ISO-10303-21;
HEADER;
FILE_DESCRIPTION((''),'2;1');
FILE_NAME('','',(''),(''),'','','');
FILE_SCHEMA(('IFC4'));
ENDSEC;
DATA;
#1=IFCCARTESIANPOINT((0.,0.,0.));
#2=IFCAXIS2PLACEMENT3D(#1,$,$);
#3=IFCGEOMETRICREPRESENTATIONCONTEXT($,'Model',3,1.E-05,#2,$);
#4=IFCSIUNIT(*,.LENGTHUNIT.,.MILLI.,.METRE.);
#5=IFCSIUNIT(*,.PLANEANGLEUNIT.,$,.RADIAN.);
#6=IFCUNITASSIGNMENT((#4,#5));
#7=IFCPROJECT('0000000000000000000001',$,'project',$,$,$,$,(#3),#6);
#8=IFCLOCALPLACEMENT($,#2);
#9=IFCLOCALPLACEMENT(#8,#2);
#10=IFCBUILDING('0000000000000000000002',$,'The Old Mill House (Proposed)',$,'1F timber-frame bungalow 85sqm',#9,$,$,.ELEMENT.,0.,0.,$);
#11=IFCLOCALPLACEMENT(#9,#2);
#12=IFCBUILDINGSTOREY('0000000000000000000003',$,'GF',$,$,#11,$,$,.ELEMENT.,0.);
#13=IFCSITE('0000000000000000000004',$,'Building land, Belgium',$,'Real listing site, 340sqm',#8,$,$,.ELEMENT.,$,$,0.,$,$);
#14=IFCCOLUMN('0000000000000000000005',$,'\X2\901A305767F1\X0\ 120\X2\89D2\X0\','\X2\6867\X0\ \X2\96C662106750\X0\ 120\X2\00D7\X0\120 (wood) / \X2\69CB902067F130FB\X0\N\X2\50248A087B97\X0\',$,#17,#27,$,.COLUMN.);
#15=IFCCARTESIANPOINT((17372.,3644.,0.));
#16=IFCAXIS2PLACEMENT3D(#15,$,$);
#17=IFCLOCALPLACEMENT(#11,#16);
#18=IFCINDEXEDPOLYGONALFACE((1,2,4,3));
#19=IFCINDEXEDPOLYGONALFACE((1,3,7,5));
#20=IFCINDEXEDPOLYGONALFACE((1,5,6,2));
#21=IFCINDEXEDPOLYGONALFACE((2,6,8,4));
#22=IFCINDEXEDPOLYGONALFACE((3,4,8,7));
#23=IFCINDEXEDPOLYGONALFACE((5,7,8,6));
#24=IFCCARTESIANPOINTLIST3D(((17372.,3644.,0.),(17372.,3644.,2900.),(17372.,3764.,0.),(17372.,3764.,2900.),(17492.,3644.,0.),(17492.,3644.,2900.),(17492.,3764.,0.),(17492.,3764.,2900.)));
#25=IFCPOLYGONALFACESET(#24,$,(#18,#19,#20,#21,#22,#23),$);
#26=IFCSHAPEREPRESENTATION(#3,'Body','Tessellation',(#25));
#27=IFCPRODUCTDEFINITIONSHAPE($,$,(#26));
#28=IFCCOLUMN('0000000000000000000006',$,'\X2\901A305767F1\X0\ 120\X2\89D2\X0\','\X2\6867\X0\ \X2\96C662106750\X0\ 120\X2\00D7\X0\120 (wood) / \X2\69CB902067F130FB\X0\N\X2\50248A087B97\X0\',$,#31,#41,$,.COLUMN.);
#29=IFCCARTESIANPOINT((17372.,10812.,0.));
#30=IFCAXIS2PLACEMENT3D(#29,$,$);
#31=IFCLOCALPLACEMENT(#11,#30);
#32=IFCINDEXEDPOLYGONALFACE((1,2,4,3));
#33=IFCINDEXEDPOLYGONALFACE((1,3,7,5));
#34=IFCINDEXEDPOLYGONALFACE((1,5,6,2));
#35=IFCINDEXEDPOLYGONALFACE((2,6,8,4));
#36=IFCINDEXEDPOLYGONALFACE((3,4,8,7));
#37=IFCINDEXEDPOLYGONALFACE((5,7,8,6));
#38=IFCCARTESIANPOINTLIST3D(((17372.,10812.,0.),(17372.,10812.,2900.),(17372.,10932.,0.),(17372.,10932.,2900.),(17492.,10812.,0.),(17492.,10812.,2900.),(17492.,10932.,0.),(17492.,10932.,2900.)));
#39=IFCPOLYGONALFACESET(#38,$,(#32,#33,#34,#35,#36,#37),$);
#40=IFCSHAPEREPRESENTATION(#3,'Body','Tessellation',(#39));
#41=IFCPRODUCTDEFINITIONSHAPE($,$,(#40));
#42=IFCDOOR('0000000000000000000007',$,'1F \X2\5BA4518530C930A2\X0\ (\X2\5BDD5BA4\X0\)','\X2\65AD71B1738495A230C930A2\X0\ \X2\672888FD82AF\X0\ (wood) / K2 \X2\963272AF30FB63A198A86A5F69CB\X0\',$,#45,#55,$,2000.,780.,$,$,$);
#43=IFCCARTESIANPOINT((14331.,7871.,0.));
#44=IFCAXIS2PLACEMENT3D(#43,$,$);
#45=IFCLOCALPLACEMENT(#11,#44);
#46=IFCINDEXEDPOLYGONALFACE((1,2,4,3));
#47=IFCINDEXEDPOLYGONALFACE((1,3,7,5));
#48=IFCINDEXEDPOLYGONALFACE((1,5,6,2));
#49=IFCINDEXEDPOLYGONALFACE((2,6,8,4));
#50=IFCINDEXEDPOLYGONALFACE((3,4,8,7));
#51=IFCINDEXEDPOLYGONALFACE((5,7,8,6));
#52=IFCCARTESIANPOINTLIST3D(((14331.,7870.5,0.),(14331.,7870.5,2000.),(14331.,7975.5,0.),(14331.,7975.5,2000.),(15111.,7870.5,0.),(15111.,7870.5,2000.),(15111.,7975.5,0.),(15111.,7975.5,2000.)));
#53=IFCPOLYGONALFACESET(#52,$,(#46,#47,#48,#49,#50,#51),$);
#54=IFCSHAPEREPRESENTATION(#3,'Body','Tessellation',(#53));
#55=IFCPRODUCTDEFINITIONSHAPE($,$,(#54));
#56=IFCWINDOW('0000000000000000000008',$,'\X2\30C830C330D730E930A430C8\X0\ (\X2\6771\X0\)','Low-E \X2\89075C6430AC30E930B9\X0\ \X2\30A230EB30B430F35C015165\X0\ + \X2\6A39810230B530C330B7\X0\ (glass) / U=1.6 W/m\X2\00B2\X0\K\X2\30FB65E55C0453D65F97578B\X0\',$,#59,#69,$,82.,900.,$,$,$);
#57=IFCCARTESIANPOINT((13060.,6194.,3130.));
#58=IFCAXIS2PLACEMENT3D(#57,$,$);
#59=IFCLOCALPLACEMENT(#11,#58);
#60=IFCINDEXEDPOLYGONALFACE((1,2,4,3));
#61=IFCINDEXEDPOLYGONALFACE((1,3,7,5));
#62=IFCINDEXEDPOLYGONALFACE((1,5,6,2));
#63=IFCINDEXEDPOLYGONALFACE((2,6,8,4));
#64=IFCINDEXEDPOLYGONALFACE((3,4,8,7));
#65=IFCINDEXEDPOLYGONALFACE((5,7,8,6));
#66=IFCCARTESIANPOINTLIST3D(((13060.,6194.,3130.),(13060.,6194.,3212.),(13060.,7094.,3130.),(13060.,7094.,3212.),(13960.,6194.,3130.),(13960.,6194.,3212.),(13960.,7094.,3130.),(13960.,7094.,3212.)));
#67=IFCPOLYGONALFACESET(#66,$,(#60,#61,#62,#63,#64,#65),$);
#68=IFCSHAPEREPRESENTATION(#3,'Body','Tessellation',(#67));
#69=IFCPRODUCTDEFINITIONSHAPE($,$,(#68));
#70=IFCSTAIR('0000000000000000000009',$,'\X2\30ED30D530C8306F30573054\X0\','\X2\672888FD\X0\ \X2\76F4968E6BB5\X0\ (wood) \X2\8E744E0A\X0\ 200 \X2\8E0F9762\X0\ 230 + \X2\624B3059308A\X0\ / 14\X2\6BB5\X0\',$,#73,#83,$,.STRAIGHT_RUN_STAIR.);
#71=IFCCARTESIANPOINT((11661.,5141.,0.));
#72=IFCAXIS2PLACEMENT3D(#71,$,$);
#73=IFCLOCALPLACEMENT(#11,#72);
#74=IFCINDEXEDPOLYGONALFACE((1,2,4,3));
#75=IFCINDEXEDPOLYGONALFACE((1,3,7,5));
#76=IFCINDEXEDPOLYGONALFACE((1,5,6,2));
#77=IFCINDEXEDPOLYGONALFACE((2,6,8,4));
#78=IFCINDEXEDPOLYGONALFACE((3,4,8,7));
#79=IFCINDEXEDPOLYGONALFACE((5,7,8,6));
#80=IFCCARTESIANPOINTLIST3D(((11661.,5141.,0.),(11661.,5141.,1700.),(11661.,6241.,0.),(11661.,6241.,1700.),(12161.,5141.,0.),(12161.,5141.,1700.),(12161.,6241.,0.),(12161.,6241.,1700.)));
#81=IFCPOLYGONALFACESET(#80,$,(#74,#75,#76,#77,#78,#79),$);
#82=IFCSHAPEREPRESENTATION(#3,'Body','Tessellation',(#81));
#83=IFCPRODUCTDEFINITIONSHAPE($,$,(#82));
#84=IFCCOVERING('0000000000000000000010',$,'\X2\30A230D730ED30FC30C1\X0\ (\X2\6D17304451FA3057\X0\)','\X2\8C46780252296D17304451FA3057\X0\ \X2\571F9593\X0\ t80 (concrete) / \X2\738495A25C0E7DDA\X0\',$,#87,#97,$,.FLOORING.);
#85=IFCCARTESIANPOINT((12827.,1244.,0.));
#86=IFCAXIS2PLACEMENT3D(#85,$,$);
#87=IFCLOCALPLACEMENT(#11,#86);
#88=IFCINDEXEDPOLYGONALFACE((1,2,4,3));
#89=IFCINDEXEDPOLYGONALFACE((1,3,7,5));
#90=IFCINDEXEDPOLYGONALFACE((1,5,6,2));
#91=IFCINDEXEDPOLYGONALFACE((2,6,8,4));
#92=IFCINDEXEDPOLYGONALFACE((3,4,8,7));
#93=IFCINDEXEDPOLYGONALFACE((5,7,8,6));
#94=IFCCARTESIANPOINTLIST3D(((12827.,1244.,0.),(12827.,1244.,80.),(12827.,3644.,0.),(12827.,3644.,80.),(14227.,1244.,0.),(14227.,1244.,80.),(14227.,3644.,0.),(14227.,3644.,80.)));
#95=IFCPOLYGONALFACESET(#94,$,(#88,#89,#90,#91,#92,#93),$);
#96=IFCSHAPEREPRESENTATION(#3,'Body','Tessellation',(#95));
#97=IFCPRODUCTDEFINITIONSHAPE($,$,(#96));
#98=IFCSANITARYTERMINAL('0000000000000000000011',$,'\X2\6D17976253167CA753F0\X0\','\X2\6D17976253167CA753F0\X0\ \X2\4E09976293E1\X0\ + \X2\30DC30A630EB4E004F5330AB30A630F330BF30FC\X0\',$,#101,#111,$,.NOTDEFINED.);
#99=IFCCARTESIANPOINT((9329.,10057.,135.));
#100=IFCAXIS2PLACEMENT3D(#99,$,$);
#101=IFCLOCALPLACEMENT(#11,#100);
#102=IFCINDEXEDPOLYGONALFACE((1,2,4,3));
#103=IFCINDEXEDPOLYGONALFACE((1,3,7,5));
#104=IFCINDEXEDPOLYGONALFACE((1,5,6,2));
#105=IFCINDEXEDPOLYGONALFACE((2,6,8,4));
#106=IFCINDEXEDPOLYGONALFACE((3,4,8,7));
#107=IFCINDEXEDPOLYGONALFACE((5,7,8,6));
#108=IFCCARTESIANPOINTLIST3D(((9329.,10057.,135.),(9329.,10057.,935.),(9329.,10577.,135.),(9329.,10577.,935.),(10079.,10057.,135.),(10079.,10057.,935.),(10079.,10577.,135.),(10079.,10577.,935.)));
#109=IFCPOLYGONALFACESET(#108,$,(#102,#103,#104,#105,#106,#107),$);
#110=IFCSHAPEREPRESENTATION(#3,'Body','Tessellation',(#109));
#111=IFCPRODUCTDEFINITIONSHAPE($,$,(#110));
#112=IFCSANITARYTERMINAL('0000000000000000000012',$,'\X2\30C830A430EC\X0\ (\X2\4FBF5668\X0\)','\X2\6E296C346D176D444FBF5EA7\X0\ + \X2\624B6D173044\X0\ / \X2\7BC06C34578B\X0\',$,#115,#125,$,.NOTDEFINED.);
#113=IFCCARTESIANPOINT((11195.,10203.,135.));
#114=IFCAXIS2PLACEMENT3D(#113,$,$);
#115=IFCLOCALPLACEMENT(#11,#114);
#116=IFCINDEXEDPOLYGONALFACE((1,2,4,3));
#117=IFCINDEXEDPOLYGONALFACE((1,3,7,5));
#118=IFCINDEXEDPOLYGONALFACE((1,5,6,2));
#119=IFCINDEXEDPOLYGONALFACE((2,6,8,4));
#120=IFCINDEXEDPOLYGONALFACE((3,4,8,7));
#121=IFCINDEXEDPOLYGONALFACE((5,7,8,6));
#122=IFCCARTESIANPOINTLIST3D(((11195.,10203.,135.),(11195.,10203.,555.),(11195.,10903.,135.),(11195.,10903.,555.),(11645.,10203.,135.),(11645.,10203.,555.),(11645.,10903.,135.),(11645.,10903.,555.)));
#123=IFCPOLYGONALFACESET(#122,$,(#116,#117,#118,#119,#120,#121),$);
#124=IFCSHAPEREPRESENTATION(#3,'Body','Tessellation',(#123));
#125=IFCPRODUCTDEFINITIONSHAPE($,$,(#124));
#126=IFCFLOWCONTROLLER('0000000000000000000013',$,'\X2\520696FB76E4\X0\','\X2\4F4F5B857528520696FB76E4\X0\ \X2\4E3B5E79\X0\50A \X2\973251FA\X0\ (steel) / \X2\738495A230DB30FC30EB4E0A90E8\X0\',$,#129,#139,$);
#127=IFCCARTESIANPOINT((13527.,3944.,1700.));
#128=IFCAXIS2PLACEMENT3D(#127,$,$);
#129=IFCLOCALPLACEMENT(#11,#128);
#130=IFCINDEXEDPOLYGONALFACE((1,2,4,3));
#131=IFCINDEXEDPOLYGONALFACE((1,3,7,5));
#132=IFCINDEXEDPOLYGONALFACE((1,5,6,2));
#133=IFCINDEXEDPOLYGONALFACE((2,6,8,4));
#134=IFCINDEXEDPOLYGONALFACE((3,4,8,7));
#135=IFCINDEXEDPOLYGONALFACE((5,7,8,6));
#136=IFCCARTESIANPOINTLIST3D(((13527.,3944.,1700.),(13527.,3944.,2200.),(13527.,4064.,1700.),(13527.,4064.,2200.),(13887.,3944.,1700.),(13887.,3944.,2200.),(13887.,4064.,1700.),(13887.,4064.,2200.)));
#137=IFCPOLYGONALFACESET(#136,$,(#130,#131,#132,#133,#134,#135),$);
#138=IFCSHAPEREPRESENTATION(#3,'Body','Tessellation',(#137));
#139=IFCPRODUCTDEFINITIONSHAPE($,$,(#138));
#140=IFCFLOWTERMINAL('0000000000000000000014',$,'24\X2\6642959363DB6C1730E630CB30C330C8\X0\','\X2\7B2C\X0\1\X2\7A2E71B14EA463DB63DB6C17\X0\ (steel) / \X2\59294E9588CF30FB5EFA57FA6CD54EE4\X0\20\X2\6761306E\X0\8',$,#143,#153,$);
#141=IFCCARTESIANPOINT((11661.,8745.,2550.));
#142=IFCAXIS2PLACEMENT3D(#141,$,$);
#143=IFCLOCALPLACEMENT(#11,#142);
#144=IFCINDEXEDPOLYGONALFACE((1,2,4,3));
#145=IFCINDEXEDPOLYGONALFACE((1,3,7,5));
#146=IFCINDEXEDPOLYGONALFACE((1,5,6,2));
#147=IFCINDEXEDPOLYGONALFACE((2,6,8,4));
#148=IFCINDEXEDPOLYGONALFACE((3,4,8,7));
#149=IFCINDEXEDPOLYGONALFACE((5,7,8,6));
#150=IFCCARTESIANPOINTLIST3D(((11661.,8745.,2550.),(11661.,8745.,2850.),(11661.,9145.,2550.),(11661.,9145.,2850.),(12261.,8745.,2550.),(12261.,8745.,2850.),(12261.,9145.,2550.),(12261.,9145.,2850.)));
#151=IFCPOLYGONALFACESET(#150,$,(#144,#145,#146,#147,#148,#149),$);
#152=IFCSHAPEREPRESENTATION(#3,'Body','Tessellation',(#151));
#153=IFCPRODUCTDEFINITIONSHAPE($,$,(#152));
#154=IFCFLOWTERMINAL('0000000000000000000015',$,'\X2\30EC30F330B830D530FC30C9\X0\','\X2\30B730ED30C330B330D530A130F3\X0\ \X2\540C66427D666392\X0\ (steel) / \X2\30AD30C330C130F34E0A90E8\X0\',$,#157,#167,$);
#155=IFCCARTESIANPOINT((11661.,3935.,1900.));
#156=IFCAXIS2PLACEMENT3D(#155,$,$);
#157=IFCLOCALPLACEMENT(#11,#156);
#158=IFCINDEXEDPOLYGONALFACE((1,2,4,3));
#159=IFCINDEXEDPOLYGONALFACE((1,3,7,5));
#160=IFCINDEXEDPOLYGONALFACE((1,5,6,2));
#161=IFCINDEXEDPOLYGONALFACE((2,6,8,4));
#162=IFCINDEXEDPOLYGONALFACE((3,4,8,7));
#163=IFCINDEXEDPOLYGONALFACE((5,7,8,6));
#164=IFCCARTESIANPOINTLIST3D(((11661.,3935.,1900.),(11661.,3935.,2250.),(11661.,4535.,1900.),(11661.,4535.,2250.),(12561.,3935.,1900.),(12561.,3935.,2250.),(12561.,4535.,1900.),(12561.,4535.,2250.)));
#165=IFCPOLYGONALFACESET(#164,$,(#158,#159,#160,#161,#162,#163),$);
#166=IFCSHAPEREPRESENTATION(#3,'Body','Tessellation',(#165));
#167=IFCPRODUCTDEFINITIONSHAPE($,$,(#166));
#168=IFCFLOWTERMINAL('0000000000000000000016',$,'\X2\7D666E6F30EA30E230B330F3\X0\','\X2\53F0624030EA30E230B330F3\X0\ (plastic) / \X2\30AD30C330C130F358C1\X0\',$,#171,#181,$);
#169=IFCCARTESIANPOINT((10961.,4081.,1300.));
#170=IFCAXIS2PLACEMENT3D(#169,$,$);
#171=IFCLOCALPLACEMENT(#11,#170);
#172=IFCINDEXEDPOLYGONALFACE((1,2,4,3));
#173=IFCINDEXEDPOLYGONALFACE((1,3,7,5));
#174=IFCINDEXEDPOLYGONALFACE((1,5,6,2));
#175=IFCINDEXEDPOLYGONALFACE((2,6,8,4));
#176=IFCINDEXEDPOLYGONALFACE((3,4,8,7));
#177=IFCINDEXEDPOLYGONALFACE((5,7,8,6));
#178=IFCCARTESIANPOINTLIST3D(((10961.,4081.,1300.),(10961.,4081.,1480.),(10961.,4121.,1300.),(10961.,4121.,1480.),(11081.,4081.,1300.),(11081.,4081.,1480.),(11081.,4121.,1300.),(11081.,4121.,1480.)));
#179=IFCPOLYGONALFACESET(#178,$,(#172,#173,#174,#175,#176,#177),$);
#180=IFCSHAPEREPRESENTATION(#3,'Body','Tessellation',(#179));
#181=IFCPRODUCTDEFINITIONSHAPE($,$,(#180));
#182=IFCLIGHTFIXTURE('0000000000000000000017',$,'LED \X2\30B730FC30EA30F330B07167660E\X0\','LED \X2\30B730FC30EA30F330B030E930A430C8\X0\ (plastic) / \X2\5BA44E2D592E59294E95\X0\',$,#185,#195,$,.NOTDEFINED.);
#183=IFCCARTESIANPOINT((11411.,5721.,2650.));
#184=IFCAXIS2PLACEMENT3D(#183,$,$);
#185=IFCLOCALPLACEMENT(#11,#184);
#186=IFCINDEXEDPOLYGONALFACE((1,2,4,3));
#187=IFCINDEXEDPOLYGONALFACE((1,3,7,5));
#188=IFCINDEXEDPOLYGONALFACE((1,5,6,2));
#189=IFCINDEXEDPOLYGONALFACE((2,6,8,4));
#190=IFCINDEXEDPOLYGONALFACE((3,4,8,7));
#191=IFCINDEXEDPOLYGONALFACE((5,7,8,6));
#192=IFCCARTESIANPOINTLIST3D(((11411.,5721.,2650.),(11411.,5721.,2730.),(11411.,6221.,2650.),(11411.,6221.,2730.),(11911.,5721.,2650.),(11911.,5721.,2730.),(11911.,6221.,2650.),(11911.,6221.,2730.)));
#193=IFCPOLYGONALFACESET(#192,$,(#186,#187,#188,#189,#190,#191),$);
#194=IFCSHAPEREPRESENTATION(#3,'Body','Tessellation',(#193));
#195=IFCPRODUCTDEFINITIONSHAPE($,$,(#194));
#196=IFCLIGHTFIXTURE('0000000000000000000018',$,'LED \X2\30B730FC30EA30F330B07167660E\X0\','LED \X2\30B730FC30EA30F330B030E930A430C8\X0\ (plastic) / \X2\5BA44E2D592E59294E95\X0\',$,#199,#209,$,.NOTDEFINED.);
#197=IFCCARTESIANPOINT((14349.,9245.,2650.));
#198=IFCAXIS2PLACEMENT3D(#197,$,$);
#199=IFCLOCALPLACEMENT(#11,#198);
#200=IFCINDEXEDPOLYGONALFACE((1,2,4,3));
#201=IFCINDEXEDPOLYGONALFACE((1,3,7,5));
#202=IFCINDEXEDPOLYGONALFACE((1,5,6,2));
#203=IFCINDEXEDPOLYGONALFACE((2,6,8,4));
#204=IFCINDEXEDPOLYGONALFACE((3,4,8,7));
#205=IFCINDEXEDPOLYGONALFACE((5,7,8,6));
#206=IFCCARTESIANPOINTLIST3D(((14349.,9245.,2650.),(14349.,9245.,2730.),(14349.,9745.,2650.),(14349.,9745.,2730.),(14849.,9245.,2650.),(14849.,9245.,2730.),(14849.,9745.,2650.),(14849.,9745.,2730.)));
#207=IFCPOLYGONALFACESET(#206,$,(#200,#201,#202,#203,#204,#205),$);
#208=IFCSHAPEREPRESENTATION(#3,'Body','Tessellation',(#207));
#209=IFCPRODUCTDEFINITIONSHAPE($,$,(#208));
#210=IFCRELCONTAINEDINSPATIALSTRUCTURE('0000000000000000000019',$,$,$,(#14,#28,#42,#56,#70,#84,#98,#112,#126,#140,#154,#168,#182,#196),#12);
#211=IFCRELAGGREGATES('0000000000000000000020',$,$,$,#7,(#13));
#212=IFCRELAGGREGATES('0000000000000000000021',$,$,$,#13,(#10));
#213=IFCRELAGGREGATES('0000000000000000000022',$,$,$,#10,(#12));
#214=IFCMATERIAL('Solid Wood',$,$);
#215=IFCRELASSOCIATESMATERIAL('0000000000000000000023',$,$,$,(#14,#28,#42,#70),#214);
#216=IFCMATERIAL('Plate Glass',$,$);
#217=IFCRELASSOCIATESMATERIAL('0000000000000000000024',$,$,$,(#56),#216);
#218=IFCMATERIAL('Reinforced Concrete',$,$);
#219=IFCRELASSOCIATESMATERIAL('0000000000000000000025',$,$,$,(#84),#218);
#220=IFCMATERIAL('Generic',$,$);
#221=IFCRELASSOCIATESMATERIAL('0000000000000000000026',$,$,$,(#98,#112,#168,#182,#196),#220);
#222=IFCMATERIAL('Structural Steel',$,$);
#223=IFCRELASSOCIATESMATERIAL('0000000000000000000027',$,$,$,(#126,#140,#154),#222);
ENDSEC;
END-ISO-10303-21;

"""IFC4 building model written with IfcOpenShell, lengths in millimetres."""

from ifc_helpers import new_model, si_unit, frame, frame_2d, origin, place, context, project, spatial, rectangle, extrude, material, element, save


model = new_model("IFC4")

# Units and contexts
model_context = context("Model", 3, precision=1e-05, world=origin())
ifc_project = project(units=[si_unit("LENGTHUNIT", "METRE", prefix="MILLI"), si_unit("PLANEANGLEUNIT", "RADIAN")], contexts=[model_context])

# Site, building, storey
site_placement = place(None, origin())
site = spatial("IfcSite", under=ifc_project, at=site_placement, Name="Building land, Belgium", ObjectType="Real listing site, 340sqm", CompositionType="ELEMENT", RefElevation=0.0)
building_placement = place(site_placement, origin())
building = spatial("IfcBuilding", under=site, at=building_placement, Name="The Old Mill House (Proposed)", ObjectType="1F timber-frame bungalow 85sqm", CompositionType="ELEMENT", ElevationOfRefHeight=0.0, ElevationOfTerrain=0.0)
storey_placement = place(building_placement, origin())
storey = spatial("IfcBuildingStorey", under=building, at=storey_placement, Name="GF", CompositionType="ELEMENT", Elevation=0.0)

# Columns
ifc_material_1 = material(Name="Solid Wood")
column_1_placement = place(storey_placement, frame((17372.0, 3644.0, 0.0)))
element("IfcColumn", 1, at=column_1_placement, inside=storey, material=ifc_material_1, Name="通し柱 120角", Description="桧 集成材 120×120 (wood) / 構造柱・N値計算", PredefinedType="COLUMN", context=model_context, shape_type="SweptSolid", body=[
    extrude(rectangle(XDim=120.0, YDim=120.0, at=frame_2d((60.0, 60.0))), frame((17372.0, 3644.0, 0.0)), (0.0, 0.0, 1.0), 2900.0),
])
column_2_placement = place(storey_placement, frame((17372.0, 10812.0, 0.0)))
element("IfcColumn", 2, at=column_2_placement, inside=storey, material=ifc_material_1, Name="通し柱 120角", Description="桧 集成材 120×120 (wood) / 構造柱・N値計算", PredefinedType="COLUMN", context=model_context, shape_type="SweptSolid", body=[
    extrude(rectangle(XDim=120.0, YDim=120.0, at=frame_2d((60.0, 60.0))), frame((17372.0, 10812.0, 0.0)), (0.0, 0.0, 1.0), 2900.0),
])

# Shared definitions
ifc_material_2 = material(Name="Plate Glass")

# Door
door_placement = place(storey_placement, frame((14331.0, 7871.0, 0.0)))
element("IfcDoor", 3, at=door_placement, inside=storey, material=ifc_material_1, Name="1F 室内ドア (寝室)", Description="断熱玄関ドア 木製芯 (wood) / K2 防犯・採風機構", OverallHeight=2000.0, OverallWidth=780.0, context=model_context, shape_type="SweptSolid", body=[
    extrude(rectangle(XDim=780.0, YDim=105.0, at=frame_2d((390.0, 52.0))), frame((14331.0, 7871.0, 0.0)), (0.0, 0.0, 1.0), 2000.0),
])

# Window
window_1_placement = place(storey_placement, frame((13060.0, 6194.0, 3130.0)))
element("IfcWindow", 4, at=window_1_placement, inside=storey, material=ifc_material_2, Name="トップライト (東)", Description="Low-E 複層ガラス アルゴン封入 + 樹脂サッシ (glass) / U=1.6 W/m²K・日射取得型", OverallHeight=82.0, OverallWidth=900.0, context=model_context, shape_type="SweptSolid", body=[
    extrude(rectangle(XDim=900.0, YDim=900.0, at=frame_2d((450.0, 450.0))), frame((13060.0, 6194.0, 3130.0)), (0.0, 0.0, 1.0), 82.0),
])

# Stair
stair_placement = place(storey_placement, frame((11661.0, 5141.0, 0.0)))
element("IfcStair", 5, at=stair_placement, inside=storey, material=ifc_material_1, Name="ロフトはしご", Description="木製 直階段 (wood) 蹴上 200 踏面 230 + 手すり / 14段", PredefinedType="STRAIGHT_RUN_STAIR", context=model_context, shape_type="SweptSolid", body=[
    extrude(rectangle(XDim=500.0, YDim=1100.0, at=frame_2d((250.0, 550.0))), frame((11661.0, 5141.0, 0.0)), (0.0, 0.0, 1.0), 1700.0),
])

# Covering
ifc_material_3 = material(Name="Reinforced Concrete")
covering_placement = place(storey_placement, frame((12827.0, 1244.0, 0.0)))
element("IfcCovering", 6, at=covering_placement, inside=storey, material=ifc_material_3, Name="アプローチ (洗い出し)", Description="豆砂利洗い出し 土間 t80 (concrete) / 玄関導線", PredefinedType="FLOORING", context=model_context, shape_type="SweptSolid", body=[
    extrude(rectangle(XDim=1400.0, YDim=2400.0, at=frame_2d((700.0, 1200.0))), frame((12827.0, 1244.0, 0.0)), (0.0, 0.0, 1.0), 80.0),
])

# Sanitary terminals
ifc_material_4 = material(Name="Generic")
sanitary_terminal_1_placement = place(storey_placement, frame((9329.0, 10057.0, 135.0)))
element("IfcSanitaryTerminal", 7, at=sanitary_terminal_1_placement, inside=storey, material=ifc_material_4, Name="洗面化粧台", Description="洗面化粧台 三面鏡 + ボウル一体カウンター", PredefinedType="NOTDEFINED", context=model_context, shape_type="SweptSolid", body=[
    extrude(rectangle(XDim=750.0, YDim=520.0, at=frame_2d((375.0, 260.0))), frame((9329.0, 10057.0, 135.0)), (0.0, 0.0, 1.0), 800.0),
])
sanitary_terminal_2_placement = place(storey_placement, frame((11195.0, 10203.0, 135.0)))
element("IfcSanitaryTerminal", 8, at=sanitary_terminal_2_placement, inside=storey, material=ifc_material_4, Name="トイレ (便器)", Description="温水洗浄便座 + 手洗い / 節水型", PredefinedType="NOTDEFINED", context=model_context, shape_type="SweptSolid", body=[
    extrude(rectangle(XDim=450.0, YDim=700.0, at=frame_2d((225.0, 350.0))), frame((11195.0, 10203.0, 135.0)), (0.0, 0.0, 1.0), 420.0),
])

# Flow controller
ifc_material_5 = material(Name="Structural Steel")
flow_controller_placement = place(storey_placement, frame((13527.0, 3944.0, 1700.0)))
element("IfcFlowController", 9, at=flow_controller_placement, inside=storey, material=ifc_material_5, Name="分電盤", Description="住宅用分電盤 主幹50A 露出 (steel) / 玄関ホール上部", context=model_context, shape_type="SweptSolid", body=[
    extrude(rectangle(XDim=360.0, YDim=120.0, at=frame_2d((180.0, 60.0))), frame((13527.0, 3944.0, 1700.0)), (0.0, 0.0, 1.0), 500.0),
])

# Flow terminals
flow_terminal_1_placement = place(storey_placement, frame((11661.0, 8745.0, 2550.0)))
element("IfcFlowTerminal", 10, at=flow_terminal_1_placement, inside=storey, material=ifc_material_5, Name="24時間換気ユニット", Description="第1種熱交換換気 (steel) / 天井裏・建基法令20条の8", context=model_context, shape_type="SweptSolid", body=[
    extrude(rectangle(XDim=600.0, YDim=400.0, at=frame_2d((300.0, 200.0))), frame((11661.0, 8745.0, 2550.0)), (0.0, 0.0, 1.0), 300.0),
])
flow_terminal_2_placement = place(storey_placement, frame((11661.0, 3935.0, 1900.0)))
element("IfcFlowTerminal", 11, at=flow_terminal_2_placement, inside=storey, material=ifc_material_5, Name="レンジフード", Description="シロッコファン 同時給排 (steel) / キッチン上部", context=model_context, shape_type="SweptSolid", body=[
    extrude(rectangle(XDim=900.0, YDim=600.0, at=frame_2d((450.0, 300.0))), frame((11661.0, 3935.0, 1900.0)), (0.0, 0.0, 1.0), 350.0),
])
flow_terminal_3_placement = place(storey_placement, frame((10961.0, 4081.0, 1300.0)))
element("IfcFlowTerminal", 12, at=flow_terminal_3_placement, inside=storey, material=ifc_material_4, Name="給湯リモコン", Description="台所リモコン (plastic) / キッチン壁", context=model_context, shape_type="SweptSolid", body=[
    extrude(rectangle(XDim=120.0, YDim=40.0, at=frame_2d((60.0, 20.0))), frame((10961.0, 4081.0, 1300.0)), (0.0, 0.0, 1.0), 180.0),
])

# Light fixtures
light_fixture_1_placement = place(storey_placement, frame((11411.0, 5721.0, 2650.0)))
element("IfcLightFixture", 13, at=light_fixture_1_placement, inside=storey, material=ifc_material_4, Name="LED シーリング照明", Description="LED シーリングライト (plastic) / 室中央天井", PredefinedType="NOTDEFINED", context=model_context, shape_type="SweptSolid", body=[
    extrude(rectangle(XDim=500.0, YDim=500.0, at=frame_2d((250.0, 250.0))), frame((11411.0, 5721.0, 2650.0)), (0.0, 0.0, 1.0), 80.0),
])
light_fixture_2_placement = place(storey_placement, frame((14349.0, 9245.0, 2650.0)))
element("IfcLightFixture", 14, at=light_fixture_2_placement, inside=storey, material=ifc_material_4, Name="LED シーリング照明", Description="LED シーリングライト (plastic) / 室中央天井", PredefinedType="NOTDEFINED", context=model_context, shape_type="SweptSolid", body=[
    extrude(rectangle(XDim=500.0, YDim=500.0, at=frame_2d((250.0, 250.0))), frame((14349.0, 9245.0, 2650.0)), (0.0, 0.0, 1.0), 80.0),
])

save(model, "model.ifc")
